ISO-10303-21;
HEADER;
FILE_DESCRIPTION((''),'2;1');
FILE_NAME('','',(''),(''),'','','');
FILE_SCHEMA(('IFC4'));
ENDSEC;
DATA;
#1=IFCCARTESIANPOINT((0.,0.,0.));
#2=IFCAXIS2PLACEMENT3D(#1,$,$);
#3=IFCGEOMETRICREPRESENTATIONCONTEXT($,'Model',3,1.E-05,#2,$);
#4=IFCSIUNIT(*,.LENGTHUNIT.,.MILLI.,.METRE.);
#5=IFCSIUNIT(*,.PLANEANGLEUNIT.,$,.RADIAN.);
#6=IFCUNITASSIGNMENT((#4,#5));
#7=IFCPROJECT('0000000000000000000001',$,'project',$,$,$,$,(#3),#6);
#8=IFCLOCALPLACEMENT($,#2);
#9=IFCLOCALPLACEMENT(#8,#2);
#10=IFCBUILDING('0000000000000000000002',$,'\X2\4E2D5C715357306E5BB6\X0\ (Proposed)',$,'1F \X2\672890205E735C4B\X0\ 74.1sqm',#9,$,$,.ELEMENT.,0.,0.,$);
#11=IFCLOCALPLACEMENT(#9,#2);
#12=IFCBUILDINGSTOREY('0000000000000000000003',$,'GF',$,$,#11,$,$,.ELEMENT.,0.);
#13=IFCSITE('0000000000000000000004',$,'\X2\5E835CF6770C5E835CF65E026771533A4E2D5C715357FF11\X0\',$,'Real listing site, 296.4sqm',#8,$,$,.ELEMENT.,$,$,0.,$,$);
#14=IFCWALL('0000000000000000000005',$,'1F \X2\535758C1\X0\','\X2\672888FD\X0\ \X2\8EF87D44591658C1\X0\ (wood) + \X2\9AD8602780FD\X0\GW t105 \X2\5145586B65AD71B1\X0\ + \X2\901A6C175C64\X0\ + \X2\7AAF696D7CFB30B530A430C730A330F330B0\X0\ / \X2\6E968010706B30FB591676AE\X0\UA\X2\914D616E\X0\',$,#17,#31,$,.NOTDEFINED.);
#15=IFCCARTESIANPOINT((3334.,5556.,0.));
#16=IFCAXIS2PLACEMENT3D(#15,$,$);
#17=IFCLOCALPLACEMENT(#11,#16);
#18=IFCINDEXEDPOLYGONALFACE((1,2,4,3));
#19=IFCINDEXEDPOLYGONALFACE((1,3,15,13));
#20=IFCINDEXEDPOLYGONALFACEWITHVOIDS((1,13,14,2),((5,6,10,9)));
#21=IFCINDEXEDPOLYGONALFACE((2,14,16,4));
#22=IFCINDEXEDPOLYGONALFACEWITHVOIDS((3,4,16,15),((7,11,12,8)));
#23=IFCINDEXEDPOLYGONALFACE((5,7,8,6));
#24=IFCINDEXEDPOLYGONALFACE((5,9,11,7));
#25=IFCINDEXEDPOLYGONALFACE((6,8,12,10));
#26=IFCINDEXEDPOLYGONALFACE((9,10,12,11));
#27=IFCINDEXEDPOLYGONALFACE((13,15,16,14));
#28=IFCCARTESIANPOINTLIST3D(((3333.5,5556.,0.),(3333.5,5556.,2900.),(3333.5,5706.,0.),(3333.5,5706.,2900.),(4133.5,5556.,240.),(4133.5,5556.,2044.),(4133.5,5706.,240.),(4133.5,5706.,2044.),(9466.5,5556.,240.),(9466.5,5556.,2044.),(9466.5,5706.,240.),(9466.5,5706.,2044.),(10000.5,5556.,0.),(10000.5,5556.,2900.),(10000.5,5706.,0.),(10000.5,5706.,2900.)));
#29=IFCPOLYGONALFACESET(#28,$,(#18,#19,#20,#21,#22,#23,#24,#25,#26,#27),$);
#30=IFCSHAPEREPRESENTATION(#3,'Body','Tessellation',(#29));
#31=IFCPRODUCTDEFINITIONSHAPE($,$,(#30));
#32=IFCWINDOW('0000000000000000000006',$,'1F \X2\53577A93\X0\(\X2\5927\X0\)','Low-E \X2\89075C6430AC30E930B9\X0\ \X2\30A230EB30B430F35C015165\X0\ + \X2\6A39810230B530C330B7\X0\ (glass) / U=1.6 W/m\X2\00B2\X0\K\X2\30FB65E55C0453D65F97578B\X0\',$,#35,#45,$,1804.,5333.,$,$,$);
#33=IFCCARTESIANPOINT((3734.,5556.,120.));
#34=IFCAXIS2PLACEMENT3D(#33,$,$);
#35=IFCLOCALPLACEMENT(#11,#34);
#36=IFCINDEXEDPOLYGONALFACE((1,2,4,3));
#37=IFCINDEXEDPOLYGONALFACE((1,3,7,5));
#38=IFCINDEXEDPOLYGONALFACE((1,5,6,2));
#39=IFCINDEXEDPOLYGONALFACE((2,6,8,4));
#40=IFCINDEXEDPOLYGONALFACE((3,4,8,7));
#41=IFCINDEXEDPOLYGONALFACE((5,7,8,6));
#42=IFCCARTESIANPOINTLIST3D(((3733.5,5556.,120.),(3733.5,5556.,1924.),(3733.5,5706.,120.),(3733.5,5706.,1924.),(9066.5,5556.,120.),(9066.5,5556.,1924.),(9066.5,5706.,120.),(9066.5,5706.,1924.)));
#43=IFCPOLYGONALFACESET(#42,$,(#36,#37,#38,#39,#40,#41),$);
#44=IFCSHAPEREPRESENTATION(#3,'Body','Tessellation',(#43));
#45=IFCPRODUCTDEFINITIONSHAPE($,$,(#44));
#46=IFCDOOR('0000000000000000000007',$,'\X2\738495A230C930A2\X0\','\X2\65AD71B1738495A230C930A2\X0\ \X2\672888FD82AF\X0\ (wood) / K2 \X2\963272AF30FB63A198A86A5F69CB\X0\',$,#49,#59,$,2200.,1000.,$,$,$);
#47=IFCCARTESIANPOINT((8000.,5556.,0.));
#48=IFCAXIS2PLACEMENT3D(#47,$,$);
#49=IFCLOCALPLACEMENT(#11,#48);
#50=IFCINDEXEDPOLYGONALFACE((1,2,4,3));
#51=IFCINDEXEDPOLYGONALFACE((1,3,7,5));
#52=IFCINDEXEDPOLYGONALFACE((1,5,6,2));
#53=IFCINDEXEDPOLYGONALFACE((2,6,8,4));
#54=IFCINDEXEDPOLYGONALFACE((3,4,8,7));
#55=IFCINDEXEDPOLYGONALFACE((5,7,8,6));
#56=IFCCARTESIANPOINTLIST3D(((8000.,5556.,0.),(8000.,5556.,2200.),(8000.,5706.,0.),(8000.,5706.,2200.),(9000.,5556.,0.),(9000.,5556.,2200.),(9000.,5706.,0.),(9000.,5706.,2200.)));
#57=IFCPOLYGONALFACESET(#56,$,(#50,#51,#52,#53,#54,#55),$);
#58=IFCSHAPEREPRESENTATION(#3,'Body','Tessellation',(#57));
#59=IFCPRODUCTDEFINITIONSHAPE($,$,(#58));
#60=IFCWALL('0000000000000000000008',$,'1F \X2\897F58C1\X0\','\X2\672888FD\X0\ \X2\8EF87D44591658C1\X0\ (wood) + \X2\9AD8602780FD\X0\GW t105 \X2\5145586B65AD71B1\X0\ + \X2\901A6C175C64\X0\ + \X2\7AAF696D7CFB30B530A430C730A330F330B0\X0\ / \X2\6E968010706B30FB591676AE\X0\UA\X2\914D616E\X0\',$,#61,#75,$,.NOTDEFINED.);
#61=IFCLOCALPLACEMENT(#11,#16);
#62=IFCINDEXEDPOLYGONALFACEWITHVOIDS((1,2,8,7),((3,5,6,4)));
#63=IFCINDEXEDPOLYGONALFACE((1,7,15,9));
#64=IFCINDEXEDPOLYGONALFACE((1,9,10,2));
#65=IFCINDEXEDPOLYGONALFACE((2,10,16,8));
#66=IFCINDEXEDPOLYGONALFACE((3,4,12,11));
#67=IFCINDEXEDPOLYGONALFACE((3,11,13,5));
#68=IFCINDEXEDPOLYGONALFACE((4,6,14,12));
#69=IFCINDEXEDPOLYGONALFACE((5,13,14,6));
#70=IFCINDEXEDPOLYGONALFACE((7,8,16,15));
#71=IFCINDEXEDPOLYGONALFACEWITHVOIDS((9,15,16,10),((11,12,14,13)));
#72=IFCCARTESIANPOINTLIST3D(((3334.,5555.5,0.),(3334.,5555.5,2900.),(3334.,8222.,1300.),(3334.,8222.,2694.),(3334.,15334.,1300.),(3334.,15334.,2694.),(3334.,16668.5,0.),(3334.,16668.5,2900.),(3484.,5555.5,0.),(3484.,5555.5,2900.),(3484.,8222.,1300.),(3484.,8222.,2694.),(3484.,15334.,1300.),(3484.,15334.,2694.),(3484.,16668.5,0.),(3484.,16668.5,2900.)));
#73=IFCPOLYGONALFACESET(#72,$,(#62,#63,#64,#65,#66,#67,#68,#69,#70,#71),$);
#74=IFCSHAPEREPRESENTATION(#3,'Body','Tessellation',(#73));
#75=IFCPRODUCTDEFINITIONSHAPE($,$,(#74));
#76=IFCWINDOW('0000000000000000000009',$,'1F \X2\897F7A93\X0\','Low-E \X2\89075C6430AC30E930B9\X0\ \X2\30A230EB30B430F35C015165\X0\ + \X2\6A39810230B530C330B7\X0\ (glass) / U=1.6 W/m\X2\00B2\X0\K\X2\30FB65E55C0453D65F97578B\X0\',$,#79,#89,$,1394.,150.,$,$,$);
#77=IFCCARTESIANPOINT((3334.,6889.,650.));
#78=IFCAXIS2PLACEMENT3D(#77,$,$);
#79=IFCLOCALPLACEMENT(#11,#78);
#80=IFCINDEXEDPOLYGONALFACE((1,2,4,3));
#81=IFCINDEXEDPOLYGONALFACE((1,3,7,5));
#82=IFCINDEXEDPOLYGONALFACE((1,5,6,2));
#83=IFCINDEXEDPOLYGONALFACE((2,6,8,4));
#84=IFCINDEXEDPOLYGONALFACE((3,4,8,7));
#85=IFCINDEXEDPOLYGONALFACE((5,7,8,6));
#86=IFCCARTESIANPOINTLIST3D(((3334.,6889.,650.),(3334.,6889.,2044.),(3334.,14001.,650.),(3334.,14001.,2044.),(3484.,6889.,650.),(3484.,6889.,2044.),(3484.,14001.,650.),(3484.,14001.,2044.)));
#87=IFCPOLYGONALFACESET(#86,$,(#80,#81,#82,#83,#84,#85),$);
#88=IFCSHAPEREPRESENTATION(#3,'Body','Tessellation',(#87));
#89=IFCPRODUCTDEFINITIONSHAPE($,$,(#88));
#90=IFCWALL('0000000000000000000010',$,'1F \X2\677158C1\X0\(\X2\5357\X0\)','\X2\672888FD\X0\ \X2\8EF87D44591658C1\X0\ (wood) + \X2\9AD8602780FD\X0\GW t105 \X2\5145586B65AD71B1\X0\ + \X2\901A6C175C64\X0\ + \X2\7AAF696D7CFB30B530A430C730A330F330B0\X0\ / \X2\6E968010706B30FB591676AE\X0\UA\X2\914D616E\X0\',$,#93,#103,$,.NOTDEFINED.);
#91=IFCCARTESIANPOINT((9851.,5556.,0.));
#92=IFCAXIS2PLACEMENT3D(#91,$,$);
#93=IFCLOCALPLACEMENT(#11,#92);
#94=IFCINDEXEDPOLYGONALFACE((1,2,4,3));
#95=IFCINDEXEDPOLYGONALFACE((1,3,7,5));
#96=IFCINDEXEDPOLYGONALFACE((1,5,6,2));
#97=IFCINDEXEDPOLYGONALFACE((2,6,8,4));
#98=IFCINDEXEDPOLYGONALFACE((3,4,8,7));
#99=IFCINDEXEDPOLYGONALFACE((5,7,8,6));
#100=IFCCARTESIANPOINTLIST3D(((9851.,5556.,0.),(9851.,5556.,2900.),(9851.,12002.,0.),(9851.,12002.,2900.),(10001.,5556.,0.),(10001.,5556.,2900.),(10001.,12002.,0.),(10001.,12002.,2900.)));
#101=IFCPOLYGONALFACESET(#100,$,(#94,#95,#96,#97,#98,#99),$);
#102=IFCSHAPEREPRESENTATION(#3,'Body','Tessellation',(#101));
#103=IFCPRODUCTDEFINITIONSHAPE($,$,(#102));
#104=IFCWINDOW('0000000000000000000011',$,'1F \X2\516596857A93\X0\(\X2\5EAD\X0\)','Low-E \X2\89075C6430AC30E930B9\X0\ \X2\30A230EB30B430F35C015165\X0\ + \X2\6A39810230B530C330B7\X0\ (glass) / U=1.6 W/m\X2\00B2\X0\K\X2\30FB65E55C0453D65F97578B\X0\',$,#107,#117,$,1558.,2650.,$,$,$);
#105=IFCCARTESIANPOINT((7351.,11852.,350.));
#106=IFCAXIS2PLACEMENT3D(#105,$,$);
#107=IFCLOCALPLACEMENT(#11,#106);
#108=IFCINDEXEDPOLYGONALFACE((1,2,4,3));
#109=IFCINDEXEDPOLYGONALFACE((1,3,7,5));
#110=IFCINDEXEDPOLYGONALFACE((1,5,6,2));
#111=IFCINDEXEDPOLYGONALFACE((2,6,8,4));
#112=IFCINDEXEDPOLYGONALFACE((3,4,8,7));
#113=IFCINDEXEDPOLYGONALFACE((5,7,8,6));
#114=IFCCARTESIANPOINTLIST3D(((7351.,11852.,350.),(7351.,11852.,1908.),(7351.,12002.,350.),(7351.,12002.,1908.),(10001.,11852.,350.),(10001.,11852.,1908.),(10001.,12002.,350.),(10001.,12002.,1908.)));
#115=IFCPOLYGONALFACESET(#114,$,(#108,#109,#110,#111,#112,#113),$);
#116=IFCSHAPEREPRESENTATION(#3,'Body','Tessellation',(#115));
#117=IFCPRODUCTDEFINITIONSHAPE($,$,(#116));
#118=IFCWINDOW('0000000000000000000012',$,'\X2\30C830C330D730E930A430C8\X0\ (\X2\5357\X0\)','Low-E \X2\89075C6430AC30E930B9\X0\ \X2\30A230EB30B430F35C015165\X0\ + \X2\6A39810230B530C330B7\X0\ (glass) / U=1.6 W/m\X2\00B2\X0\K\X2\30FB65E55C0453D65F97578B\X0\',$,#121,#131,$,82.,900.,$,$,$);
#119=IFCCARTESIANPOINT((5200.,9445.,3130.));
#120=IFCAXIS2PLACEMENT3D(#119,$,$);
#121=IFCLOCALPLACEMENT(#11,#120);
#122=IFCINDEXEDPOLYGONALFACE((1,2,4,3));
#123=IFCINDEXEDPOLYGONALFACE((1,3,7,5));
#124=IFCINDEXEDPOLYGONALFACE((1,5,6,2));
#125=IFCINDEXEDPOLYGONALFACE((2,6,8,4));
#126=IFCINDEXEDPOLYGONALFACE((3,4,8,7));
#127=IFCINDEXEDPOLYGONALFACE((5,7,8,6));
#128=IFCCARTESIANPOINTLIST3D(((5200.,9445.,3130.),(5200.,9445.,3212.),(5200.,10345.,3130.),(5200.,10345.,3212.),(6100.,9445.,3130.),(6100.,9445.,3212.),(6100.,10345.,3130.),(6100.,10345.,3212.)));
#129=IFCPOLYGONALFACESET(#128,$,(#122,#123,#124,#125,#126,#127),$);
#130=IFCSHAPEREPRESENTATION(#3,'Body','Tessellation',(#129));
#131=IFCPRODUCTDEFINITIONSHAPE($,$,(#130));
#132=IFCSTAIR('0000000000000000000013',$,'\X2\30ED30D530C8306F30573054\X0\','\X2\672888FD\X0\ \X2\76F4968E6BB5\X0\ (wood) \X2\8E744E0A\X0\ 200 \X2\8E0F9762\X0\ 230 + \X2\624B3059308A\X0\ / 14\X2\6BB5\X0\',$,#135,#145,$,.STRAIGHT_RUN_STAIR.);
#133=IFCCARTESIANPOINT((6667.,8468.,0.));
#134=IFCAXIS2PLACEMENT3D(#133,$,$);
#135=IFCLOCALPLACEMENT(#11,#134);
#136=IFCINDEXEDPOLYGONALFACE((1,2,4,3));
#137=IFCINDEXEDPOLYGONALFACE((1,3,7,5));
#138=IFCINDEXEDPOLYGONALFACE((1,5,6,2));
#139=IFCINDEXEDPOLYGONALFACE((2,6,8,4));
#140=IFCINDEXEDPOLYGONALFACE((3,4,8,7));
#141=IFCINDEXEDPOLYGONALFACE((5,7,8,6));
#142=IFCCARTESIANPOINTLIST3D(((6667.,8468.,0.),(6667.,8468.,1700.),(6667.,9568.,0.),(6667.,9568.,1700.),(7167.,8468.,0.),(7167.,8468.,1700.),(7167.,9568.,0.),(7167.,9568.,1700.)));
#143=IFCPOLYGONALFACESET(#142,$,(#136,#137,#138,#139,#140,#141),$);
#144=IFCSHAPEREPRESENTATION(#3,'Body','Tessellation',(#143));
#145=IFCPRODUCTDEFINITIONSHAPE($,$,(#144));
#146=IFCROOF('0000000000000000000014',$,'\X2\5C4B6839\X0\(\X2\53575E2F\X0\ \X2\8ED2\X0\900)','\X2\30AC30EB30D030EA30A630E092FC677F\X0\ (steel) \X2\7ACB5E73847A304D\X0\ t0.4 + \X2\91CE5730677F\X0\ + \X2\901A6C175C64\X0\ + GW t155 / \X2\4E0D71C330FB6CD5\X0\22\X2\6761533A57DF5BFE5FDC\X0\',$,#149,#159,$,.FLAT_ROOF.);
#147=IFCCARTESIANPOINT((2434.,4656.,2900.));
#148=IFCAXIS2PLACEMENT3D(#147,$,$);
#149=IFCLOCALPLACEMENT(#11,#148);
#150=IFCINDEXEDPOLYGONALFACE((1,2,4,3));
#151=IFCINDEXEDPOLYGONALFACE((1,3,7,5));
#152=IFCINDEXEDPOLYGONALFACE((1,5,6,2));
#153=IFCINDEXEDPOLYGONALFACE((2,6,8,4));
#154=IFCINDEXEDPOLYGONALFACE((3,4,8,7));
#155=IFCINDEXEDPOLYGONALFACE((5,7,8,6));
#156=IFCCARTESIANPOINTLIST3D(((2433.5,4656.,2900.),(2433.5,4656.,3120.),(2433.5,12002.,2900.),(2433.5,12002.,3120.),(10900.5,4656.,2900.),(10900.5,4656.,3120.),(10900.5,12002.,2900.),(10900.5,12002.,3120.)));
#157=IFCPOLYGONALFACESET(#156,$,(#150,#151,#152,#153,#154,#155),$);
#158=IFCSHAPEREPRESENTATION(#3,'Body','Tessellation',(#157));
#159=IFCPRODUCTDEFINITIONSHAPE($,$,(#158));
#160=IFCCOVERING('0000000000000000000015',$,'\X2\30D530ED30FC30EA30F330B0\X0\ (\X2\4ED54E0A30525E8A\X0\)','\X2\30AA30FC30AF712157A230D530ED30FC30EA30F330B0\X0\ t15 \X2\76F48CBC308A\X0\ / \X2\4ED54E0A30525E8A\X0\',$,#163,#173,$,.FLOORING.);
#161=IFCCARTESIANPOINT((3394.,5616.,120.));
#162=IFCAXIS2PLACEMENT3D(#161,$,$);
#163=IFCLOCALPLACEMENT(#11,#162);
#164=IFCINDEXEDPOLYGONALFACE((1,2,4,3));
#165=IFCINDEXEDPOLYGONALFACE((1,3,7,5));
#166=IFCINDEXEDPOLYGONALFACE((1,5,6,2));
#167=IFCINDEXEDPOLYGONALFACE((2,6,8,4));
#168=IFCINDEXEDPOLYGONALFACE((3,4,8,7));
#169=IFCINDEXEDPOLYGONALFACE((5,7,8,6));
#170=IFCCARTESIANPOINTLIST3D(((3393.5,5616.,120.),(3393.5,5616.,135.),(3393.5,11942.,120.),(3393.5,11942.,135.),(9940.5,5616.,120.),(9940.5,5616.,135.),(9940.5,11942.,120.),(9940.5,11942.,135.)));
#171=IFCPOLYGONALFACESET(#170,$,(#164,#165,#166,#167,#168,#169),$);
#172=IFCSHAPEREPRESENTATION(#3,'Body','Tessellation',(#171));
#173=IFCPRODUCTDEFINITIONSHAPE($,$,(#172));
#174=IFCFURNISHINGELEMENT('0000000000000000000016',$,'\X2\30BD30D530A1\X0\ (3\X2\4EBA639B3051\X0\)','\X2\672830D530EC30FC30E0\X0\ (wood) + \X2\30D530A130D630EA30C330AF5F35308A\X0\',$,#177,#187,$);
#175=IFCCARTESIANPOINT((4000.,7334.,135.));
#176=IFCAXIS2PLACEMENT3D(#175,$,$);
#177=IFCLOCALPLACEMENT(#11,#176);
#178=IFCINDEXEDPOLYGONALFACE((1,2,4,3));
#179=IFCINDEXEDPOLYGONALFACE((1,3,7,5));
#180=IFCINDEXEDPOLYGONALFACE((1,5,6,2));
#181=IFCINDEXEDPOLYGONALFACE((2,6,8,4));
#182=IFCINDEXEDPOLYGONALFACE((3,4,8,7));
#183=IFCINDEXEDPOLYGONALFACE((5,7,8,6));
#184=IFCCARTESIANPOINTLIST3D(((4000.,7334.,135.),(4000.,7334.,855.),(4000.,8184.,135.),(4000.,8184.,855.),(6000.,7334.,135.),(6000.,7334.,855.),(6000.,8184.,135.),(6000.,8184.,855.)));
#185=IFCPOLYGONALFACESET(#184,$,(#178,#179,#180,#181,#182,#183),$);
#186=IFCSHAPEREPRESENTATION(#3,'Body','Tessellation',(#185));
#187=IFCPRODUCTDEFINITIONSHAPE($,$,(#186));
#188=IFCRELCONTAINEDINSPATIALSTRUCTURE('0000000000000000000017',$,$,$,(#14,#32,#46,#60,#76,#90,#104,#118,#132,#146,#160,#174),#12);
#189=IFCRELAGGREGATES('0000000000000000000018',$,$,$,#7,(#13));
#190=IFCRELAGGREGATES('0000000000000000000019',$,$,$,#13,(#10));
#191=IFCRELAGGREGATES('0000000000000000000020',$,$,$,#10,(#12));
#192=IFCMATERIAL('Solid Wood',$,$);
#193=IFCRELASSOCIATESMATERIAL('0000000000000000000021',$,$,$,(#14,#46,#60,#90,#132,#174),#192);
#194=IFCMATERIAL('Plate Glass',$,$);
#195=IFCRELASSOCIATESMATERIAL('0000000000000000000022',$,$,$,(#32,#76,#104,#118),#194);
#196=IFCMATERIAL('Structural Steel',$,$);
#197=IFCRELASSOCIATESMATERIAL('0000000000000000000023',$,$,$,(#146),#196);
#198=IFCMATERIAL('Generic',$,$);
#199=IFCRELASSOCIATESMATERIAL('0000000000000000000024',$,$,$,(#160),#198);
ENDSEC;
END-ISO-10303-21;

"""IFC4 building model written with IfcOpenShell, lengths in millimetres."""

from ifc_helpers import new_model, si_unit, frame, frame_2d, origin, place, context, project, spatial, rectangle, extrude, material, element, fill, save


model = new_model("IFC4")

# Units and contexts
model_context = context("Model", 3, precision=1e-05, world=origin())
ifc_project = project(units=[si_unit("LENGTHUNIT", "METRE", prefix="MILLI"), si_unit("PLANEANGLEUNIT", "RADIAN")], contexts=[model_context])

# Site, building, storey
site_placement = place(None, origin())
site = spatial("IfcSite", under=ifc_project, at=site_placement, Name="広島県広島市東区中山南１", ObjectType="Real listing site, 296.4sqm", CompositionType="ELEMENT", RefElevation=0.0)
building_placement = place(site_placement, origin())
building = spatial("IfcBuilding", under=site, at=building_placement, Name="中山南の家 (Proposed)", ObjectType="1F 木造平屋 74.1sqm", CompositionType="ELEMENT", ElevationOfRefHeight=0.0, ElevationOfTerrain=0.0)
storey_placement = place(building_placement, origin())
storey = spatial("IfcBuildingStorey", under=building, at=storey_placement, Name="GF", CompositionType="ELEMENT", Elevation=0.0)

# Shared definitions
ifc_material_1 = material(Name="Solid Wood")

# Wall, openings, window, door
wall_1_placement = place(storey_placement, frame((3334.0, 5556.0, 0.0)))
wall_1 = element("IfcWall", 1, at=wall_1_placement, inside=storey, material=ifc_material_1, Name="1F 南壁", Description="木製 軸組外壁 (wood) + 高性能GW t105 充填断熱 + 通気層 + 窯業系サイディング / 準耐火・外皮UA配慮", PredefinedType="NOTDEFINED", context=model_context, shape_type="SweptSolid", body=[
    extrude(rectangle(XDim=6667.0, YDim=150.0, at=frame_2d((3333.0, 75.0))), frame((3334.0, 5556.0, 0.0)), (0.0, 0.0, 1.0), 2900.0),
])
opening_1_placement = place(storey_placement, frame((3734.0, 5556.0, 120.0)))
opening_1 = element("IfcOpeningElement", 2, at=opening_1_placement, cuts=wall_1, PredefinedType="NOTDEFINED", context=model_context, shape_type="SweptSolid", body=[
    extrude(rectangle(XDim=5333.0, YDim=150.0, at=frame_2d((2666.0, 75.0))), frame((3734.0, 5556.0, 120.0)), (0.0, 0.0, 1.0), 1804.0),
])
opening_2_placement = place(storey_placement, frame((8000.0, 5556.0, 0.0)))
opening_2 = element("IfcOpeningElement", 3, at=opening_2_placement, cuts=wall_1, PredefinedType="NOTDEFINED", context=model_context, shape_type="SweptSolid", body=[
    extrude(rectangle(XDim=1000.0, YDim=150.0, at=frame_2d((500.0, 75.0))), frame((8000.0, 5556.0, 0.0)), (0.0, 0.0, 1.0), 2200.0),
])
ifc_material_2 = material(Name="Plate Glass")
window_1_placement = place(storey_placement, frame((3734.0, 5556.0, 120.0)))
window_1 = element("IfcWindow", 4, at=window_1_placement, inside=storey, material=ifc_material_2, Name="1F 南窓(大)", Description="Low-E 複層ガラス アルゴン封入 + 樹脂サッシ (glass) / U=1.6 W/m²K・日射取得型", OverallHeight=1804.0, OverallWidth=5333.0, context=model_context, shape_type="SweptSolid", body=[
    extrude(rectangle(XDim=5333.0, YDim=150.0, at=frame_2d((2666.0, 75.0))), frame((3734.0, 5556.0, 120.0)), (0.0, 0.0, 1.0), 1804.0),
])
fill(opening_1, window_1)
door_1_placement = place(storey_placement, frame((8000.0, 5556.0, 0.0)))
door_1 = element("IfcDoor", 5, at=door_1_placement, inside=storey, material=ifc_material_1, Name="玄関ドア", Description="断熱玄関ドア 木製芯 (wood) / K2 防犯・採風機構", OverallHeight=2200.0, OverallWidth=1000.0, context=model_context, shape_type="SweptSolid", body=[
    extrude(rectangle(XDim=1000.0, YDim=150.0, at=frame_2d((500.0, 75.0))), frame((8000.0, 5556.0, 0.0)), (0.0, 0.0, 1.0), 2200.0),
])
fill(opening_2, door_1)

# Walls, openings, windows
wall_2_placement = place(storey_placement, frame((3334.0, 5556.0, 0.0)))
wall_2 = element("IfcWall", 6, at=wall_2_placement, inside=storey, material=ifc_material_1, Name="1F 西壁", Description="木製 軸組外壁 (wood) + 高性能GW t105 充填断熱 + 通気層 + 窯業系サイディング / 準耐火・外皮UA配慮", PredefinedType="NOTDEFINED", context=model_context, shape_type="SweptSolid", body=[
    extrude(rectangle(XDim=150.0, YDim=11113.0, at=frame_2d((75.0, 5556.0))), frame((3334.0, 5556.0, 0.0)), (0.0, 0.0, 1.0), 2900.0),
])
opening_3_placement = place(storey_placement, frame((3334.0, 6889.0, 650.0)))
opening_3 = element("IfcOpeningElement", 7, at=opening_3_placement, cuts=wall_2, PredefinedType="NOTDEFINED", context=model_context, shape_type="SweptSolid", body=[
    extrude(rectangle(XDim=150.0, YDim=7112.0, at=frame_2d((75.0, 3556.0))), frame((3334.0, 6889.0, 650.0)), (0.0, 0.0, 1.0), 1394.0),
])
window_2_placement = place(storey_placement, frame((3334.0, 6889.0, 650.0)))
window_2 = element("IfcWindow", 8, at=window_2_placement, inside=storey, material=ifc_material_2, Name="1F 西窓", Description="Low-E 複層ガラス アルゴン封入 + 樹脂サッシ (glass) / U=1.6 W/m²K・日射取得型", OverallHeight=1394.0, OverallWidth=150.0, context=model_context, shape_type="SweptSolid", body=[
    extrude(rectangle(XDim=150.0, YDim=7112.0, at=frame_2d((75.0, 3556.0))), frame((3334.0, 6889.0, 650.0)), (0.0, 0.0, 1.0), 1394.0),
])
fill(opening_3, window_2)
wall_3_placement = place(storey_placement, frame((9851.0, 5556.0, 0.0)))
wall_3 = element("IfcWall", 9, at=wall_3_placement, inside=storey, material=ifc_material_1, Name="1F 東壁(南)", Description="木製 軸組外壁 (wood) + 高性能GW t105 充填断熱 + 通気層 + 窯業系サイディング / 準耐火・外皮UA配慮", PredefinedType="NOTDEFINED", context=model_context, shape_type="SweptSolid", body=[
    extrude(rectangle(XDim=150.0, YDim=6446.0, at=frame_2d((75.0, 3223.0))), frame((9851.0, 5556.0, 0.0)), (0.0, 0.0, 1.0), 2900.0),
])
opening_4_placement = place(storey_placement, frame((7351.0, 11852.0, 350.0)))
opening_4 = element("IfcOpeningElement", 10, at=opening_4_placement, cuts=wall_3, PredefinedType="NOTDEFINED", context=model_context, shape_type="SweptSolid", body=[
    extrude(rectangle(XDim=2650.0, YDim=150.0, at=frame_2d((1325.0, 75.0))), frame((7351.0, 11852.0, 350.0)), (0.0, 0.0, 1.0), 1558.0),
])
window_3_placement = place(storey_placement, frame((7351.0, 11852.0, 350.0)))
window_3 = element("IfcWindow", 11, at=window_3_placement, inside=storey, material=ifc_material_2, Name="1F 入隅窓(庭)", Description="Low-E 複層ガラス アルゴン封入 + 樹脂サッシ (glass) / U=1.6 W/m²K・日射取得型", OverallHeight=1558.0, OverallWidth=2650.0, context=model_context, shape_type="SweptSolid", body=[
    extrude(rectangle(XDim=2650.0, YDim=150.0, at=frame_2d((1325.0, 75.0))), frame((7351.0, 11852.0, 350.0)), (0.0, 0.0, 1.0), 1558.0),
])
fill(opening_4, window_3)

# Window
window_4_placement = place(storey_placement, frame((5200.0, 9445.0, 3130.0)))
element("IfcWindow", 12, at=window_4_placement, inside=storey, material=ifc_material_2, Name="トップライト (南)", Description="Low-E 複層ガラス アルゴン封入 + 樹脂サッシ (glass) / U=1.6 W/m²K・日射取得型", OverallHeight=82.0, OverallWidth=900.0, context=model_context, shape_type="SweptSolid", body=[
    extrude(rectangle(XDim=900.0, YDim=900.0, at=frame_2d((450.0, 450.0))), frame((5200.0, 9445.0, 3130.0)), (0.0, 0.0, 1.0), 82.0),
])

# Stair
stair_placement = place(storey_placement, frame((6667.0, 8468.0, 0.0)))
element("IfcStair", 13, at=stair_placement, inside=storey, material=ifc_material_1, Name="ロフトはしご", Description="木製 直階段 (wood) 蹴上 200 踏面 230 + 手すり / 14段", PredefinedType="STRAIGHT_RUN_STAIR", context=model_context, shape_type="SweptSolid", body=[
    extrude(rectangle(XDim=500.0, YDim=1100.0, at=frame_2d((250.0, 550.0))), frame((6667.0, 8468.0, 0.0)), (0.0, 0.0, 1.0), 1700.0),
])

# Roof
ifc_material_3 = material(Name="Structural Steel")
roof_placement = place(storey_placement, frame((2434.0, 4656.0, 2900.0)))
element("IfcRoof", 14, at=roof_placement, inside=storey, material=ifc_material_3, Name="屋根(南帯 軒900)", Description="ガルバリウム鋼板 (steel) 立平葺き t0.4 + 野地板 + 通気層 + GW t155 / 不燃・法22条区域対応", PredefinedType="FLAT_ROOF", context=model_context, shape_type="SweptSolid", body=[
    extrude(rectangle(XDim=8467.0, YDim=7346.0, at=frame_2d((4233.0, 3673.0))), frame((2434.0, 4656.0, 2900.0)), (0.0, 0.0, 1.0), 220.0),
])

# Covering
ifc_material_4 = material(Name="Generic")
covering_placement = place(storey_placement, frame((3394.0, 5616.0, 120.0)))
element("IfcCovering", 15, at=covering_placement, inside=storey, material=ifc_material_4, Name="フローリング (仕上げ床)", Description="オーク無垢フローリング t15 直貼り / 仕上げ床", PredefinedType="FLOORING", context=model_context, shape_type="SweptSolid", body=[
    extrude(rectangle(XDim=6547.0, YDim=6326.0, at=frame_2d((3273.0, 3163.0))), frame((3394.0, 5616.0, 120.0)), (0.0, 0.0, 1.0), 15.0),
])

# Furnishing element
furnishing_1_placement = place(storey_placement, frame((4000.0, 7334.0, 135.0)))
element("IfcFurnishingElement", 16, at=furnishing_1_placement, inside=storey, material=ifc_material_1, Name="ソファ (3人掛け)", Description="木フレーム (wood) + ファブリック張り", context=model_context, shape_type="SweptSolid", body=[
    extrude(rectangle(XDim=2000.0, YDim=850.0, at=frame_2d((1000.0, 425.0))), frame((4000.0, 7334.0, 135.0)), (0.0, 0.0, 1.0), 720.0),
])

save(model, "model.ifc")
